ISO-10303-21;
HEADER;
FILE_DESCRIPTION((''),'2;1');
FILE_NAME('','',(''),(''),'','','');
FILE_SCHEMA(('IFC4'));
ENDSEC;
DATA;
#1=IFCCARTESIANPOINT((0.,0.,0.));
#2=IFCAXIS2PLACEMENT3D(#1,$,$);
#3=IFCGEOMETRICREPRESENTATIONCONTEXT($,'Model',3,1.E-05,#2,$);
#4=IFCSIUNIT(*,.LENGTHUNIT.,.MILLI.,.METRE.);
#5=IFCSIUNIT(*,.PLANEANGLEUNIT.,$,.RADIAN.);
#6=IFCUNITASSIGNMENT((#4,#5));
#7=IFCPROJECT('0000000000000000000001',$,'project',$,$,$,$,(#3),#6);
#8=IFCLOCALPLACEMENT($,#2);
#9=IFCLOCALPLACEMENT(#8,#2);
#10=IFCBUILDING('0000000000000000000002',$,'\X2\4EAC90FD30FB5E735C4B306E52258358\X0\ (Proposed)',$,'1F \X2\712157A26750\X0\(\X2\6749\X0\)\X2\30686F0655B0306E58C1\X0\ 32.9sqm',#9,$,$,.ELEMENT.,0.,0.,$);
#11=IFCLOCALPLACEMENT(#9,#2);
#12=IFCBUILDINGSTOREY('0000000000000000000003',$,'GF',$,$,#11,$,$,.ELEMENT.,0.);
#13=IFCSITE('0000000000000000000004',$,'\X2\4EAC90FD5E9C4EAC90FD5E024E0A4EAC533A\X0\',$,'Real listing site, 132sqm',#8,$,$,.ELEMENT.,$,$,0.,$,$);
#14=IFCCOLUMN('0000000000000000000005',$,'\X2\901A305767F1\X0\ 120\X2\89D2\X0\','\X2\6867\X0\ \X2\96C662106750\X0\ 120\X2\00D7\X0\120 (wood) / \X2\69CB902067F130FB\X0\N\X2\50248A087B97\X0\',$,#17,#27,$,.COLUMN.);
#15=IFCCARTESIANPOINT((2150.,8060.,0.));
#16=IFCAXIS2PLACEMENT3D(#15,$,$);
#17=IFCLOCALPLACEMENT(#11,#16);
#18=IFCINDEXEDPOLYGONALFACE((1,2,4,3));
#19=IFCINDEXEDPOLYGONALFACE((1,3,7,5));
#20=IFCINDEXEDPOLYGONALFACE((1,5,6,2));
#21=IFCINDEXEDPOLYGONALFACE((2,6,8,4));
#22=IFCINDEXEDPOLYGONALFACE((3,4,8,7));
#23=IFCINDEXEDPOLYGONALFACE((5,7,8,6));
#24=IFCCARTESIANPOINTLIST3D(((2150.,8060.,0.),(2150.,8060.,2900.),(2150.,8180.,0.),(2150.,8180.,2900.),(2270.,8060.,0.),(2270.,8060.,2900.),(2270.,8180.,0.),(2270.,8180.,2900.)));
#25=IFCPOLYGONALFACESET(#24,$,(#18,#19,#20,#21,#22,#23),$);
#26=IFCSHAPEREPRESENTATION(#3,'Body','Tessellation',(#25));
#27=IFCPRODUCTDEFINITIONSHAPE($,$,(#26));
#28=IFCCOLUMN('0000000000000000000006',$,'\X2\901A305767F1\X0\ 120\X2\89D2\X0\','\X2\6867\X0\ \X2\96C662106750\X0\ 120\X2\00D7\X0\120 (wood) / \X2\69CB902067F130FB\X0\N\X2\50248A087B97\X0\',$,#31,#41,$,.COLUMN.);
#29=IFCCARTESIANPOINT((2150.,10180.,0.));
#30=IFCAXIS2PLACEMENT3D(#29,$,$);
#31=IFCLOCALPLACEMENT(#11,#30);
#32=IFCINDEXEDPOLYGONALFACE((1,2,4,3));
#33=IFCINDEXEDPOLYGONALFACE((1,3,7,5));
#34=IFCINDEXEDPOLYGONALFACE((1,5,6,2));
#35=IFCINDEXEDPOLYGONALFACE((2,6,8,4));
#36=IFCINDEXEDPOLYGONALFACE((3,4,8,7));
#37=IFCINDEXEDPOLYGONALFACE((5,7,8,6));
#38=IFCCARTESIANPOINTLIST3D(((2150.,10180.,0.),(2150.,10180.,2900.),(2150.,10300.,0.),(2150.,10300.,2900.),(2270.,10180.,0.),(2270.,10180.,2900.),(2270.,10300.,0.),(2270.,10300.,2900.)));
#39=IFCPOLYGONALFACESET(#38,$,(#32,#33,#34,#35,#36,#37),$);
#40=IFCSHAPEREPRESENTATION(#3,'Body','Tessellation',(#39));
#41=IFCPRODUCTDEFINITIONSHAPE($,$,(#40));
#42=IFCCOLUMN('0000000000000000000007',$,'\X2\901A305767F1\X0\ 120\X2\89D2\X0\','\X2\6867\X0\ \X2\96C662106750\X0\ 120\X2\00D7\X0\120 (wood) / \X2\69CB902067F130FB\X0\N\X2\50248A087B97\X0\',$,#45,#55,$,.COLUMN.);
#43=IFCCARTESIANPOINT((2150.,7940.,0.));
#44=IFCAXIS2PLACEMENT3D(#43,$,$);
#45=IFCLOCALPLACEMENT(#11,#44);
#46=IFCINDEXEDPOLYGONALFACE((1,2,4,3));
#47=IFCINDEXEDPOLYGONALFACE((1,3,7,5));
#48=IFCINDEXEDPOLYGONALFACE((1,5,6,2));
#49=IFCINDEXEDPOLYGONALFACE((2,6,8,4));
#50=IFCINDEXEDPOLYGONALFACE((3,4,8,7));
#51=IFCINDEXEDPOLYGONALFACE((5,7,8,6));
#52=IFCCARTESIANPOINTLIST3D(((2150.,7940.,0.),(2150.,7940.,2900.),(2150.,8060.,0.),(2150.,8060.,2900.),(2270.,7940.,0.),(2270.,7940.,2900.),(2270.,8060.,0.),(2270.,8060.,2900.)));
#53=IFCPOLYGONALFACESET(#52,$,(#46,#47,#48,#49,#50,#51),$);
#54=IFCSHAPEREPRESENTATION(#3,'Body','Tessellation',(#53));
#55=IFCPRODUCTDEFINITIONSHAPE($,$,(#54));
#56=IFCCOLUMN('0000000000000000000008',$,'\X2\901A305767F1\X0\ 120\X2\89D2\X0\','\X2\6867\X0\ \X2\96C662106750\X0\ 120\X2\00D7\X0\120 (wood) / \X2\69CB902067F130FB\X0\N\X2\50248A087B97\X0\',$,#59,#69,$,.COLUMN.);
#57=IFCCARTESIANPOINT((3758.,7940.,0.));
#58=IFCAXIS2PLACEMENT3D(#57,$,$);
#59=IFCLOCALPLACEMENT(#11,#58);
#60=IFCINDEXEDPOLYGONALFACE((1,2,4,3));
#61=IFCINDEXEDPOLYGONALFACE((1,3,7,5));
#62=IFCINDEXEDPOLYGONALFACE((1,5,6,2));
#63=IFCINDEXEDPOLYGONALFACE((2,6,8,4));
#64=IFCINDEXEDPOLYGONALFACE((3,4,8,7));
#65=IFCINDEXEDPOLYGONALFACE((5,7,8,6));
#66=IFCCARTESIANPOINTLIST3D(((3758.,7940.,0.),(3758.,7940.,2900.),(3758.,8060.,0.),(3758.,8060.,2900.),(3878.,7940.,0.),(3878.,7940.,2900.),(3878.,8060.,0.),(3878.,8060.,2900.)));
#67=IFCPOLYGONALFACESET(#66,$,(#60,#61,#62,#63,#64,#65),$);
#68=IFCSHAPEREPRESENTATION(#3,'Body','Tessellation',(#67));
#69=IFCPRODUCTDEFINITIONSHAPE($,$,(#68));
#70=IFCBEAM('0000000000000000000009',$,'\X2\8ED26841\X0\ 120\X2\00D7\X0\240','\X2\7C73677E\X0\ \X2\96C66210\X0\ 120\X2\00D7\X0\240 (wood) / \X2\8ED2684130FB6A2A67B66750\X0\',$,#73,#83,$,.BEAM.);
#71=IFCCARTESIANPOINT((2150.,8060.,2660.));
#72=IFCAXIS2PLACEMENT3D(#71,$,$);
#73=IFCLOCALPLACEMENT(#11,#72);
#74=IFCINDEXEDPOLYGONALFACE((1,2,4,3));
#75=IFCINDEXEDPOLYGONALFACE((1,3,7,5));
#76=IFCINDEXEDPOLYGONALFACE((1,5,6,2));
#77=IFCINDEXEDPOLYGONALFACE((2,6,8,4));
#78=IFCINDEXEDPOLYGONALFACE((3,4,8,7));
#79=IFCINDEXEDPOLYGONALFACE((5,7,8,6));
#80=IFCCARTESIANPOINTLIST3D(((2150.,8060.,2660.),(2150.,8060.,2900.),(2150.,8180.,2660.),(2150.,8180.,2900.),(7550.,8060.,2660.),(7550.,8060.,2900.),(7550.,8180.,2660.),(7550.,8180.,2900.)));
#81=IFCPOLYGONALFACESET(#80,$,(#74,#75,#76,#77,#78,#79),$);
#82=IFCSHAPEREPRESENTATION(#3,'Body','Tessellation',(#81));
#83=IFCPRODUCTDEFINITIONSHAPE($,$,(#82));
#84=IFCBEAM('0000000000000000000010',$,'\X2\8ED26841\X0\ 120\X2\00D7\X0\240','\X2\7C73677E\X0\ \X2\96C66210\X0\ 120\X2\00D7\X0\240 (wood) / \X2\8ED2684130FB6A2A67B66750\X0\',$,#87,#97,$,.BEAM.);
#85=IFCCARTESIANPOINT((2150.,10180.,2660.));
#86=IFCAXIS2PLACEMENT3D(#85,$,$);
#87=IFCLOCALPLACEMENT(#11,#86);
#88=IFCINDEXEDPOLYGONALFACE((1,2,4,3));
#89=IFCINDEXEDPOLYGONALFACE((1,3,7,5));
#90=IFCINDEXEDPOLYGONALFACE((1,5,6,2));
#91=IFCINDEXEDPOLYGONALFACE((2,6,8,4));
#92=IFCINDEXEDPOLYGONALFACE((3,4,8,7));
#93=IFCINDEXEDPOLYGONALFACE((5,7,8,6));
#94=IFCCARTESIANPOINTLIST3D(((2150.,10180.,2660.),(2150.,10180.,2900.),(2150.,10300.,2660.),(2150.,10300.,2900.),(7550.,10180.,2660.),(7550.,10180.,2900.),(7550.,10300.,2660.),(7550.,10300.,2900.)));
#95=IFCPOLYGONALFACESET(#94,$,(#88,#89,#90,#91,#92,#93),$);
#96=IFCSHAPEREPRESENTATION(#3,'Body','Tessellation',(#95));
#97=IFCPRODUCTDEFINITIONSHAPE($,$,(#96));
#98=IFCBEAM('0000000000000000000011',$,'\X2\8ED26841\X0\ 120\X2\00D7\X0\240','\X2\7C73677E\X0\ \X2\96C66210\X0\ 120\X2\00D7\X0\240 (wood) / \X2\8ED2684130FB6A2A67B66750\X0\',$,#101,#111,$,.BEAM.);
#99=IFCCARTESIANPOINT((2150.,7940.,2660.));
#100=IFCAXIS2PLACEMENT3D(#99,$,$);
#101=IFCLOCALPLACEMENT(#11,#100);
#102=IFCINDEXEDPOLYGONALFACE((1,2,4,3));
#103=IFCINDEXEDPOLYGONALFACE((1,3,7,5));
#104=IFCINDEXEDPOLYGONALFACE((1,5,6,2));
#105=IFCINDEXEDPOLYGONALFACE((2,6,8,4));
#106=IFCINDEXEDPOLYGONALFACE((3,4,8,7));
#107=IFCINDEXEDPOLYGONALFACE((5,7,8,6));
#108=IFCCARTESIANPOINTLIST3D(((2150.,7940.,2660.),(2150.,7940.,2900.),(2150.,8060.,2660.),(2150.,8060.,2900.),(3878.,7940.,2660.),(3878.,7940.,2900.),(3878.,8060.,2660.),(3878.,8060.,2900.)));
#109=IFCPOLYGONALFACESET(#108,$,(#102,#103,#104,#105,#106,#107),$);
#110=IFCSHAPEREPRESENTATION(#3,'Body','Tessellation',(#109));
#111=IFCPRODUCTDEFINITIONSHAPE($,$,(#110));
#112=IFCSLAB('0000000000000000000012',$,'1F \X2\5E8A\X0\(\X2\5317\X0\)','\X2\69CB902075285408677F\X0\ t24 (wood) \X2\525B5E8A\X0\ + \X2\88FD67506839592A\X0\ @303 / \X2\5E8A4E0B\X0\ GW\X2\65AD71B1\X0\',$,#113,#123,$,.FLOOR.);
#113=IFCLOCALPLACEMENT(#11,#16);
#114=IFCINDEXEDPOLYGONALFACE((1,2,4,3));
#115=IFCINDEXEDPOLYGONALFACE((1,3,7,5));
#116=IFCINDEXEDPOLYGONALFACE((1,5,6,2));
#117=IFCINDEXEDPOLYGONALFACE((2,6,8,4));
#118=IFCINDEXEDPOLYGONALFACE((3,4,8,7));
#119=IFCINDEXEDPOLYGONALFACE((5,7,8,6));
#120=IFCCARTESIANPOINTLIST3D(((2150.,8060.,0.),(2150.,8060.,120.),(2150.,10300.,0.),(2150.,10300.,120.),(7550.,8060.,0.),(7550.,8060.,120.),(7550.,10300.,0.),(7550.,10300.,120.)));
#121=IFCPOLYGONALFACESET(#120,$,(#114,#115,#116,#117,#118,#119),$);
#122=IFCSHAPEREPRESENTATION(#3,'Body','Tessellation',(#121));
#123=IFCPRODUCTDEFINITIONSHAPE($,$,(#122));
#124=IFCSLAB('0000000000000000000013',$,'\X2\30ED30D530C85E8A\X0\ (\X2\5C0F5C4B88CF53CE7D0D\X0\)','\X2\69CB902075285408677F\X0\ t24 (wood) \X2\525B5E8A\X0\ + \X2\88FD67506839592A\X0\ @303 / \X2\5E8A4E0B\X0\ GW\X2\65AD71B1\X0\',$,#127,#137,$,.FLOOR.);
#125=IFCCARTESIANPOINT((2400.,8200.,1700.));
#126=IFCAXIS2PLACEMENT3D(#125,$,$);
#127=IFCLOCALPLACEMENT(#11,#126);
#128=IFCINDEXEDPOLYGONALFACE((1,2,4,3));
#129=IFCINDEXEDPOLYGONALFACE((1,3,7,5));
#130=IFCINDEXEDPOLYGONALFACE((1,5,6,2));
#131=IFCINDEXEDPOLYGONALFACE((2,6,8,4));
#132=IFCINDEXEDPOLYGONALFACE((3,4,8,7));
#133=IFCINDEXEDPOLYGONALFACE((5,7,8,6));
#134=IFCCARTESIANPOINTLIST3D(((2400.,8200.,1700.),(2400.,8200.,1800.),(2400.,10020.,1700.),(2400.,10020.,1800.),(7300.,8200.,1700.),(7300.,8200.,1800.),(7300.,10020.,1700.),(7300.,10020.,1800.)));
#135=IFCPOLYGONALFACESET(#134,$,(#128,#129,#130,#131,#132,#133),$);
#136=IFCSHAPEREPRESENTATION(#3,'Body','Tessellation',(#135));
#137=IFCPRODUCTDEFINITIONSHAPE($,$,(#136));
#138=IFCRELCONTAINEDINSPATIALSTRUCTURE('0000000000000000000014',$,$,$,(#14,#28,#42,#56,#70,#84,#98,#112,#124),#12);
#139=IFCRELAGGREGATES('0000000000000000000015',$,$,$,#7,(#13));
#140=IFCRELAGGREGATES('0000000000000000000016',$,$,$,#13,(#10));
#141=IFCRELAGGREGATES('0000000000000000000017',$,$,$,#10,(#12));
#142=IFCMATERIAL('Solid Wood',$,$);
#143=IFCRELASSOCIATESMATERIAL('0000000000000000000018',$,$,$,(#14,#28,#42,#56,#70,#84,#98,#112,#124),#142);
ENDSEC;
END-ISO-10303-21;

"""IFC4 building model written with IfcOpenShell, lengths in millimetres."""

from ifc_helpers import new_model, si_unit, frame, frame_2d, origin, place, context, project, spatial, rectangle, extrude, material, element, save


model = new_model("IFC4")

# Units and contexts
model_context = context("Model", 3, precision=1e-05, world=origin())
ifc_project = project(units=[si_unit("LENGTHUNIT", "METRE", prefix="MILLI"), si_unit("PLANEANGLEUNIT", "RADIAN")], contexts=[model_context])

# Site, building, storey
site_placement = place(None, origin())
site = spatial("IfcSite", under=ifc_project, at=site_placement, Name="京都府京都市上京区", ObjectType="Real listing site, 132sqm", CompositionType="ELEMENT", RefElevation=0.0)
building_placement = place(site_placement, origin())
building = spatial("IfcBuilding", under=site, at=building_placement, Name="京都・平屋の別荘 (Proposed)", ObjectType="1F 無垢材(杉)と漆喰の壁 32.9sqm", CompositionType="ELEMENT", ElevationOfRefHeight=0.0, ElevationOfTerrain=0.0)
storey_placement = place(building_placement, origin())
storey = spatial("IfcBuildingStorey", under=building, at=storey_placement, Name="GF", CompositionType="ELEMENT", Elevation=0.0)

# Columns
ifc_material_1 = material(Name="Solid Wood")
column_1_placement = place(storey_placement, frame((2150.0, 8060.0, 0.0)))
element("IfcColumn", 1, at=column_1_placement, inside=storey, material=ifc_material_1, Name="通し柱 120角", Description="桧 集成材 120×120 (wood) / 構造柱・N値計算", PredefinedType="COLUMN", context=model_context, shape_type="SweptSolid", body=[
    extrude(rectangle(XDim=120.0, YDim=120.0, at=frame_2d((60.0, 60.0))), frame((2150.0, 8060.0, 0.0)), (0.0, 0.0, 1.0), 2900.0),
])
column_2_placement = place(storey_placement, frame((2150.0, 10180.0, 0.0)))
element("IfcColumn", 2, at=column_2_placement, inside=storey, material=ifc_material_1, Name="通し柱 120角", Description="桧 集成材 120×120 (wood) / 構造柱・N値計算", PredefinedType="COLUMN", context=model_context, shape_type="SweptSolid", body=[
    extrude(rectangle(XDim=120.0, YDim=120.0, at=frame_2d((60.0, 60.0))), frame((2150.0, 10180.0, 0.0)), (0.0, 0.0, 1.0), 2900.0),
])
column_3_placement = place(storey_placement, frame((2150.0, 7940.0, 0.0)))
element("IfcColumn", 3, at=column_3_placement, inside=storey, material=ifc_material_1, Name="通し柱 120角", Description="桧 集成材 120×120 (wood) / 構造柱・N値計算", PredefinedType="COLUMN", context=model_context, shape_type="SweptSolid", body=[
    extrude(rectangle(XDim=120.0, YDim=120.0, at=frame_2d((60.0, 60.0))), frame((2150.0, 7940.0, 0.0)), (0.0, 0.0, 1.0), 2900.0),
])
column_4_placement = place(storey_placement, frame((3758.0, 7940.0, 0.0)))
element("IfcColumn", 4, at=column_4_placement, inside=storey, material=ifc_material_1, Name="通し柱 120角", Description="桧 集成材 120×120 (wood) / 構造柱・N値計算", PredefinedType="COLUMN", context=model_context, shape_type="SweptSolid", body=[
    extrude(rectangle(XDim=120.0, YDim=120.0, at=frame_2d((60.0, 60.0))), frame((3758.0, 7940.0, 0.0)), (0.0, 0.0, 1.0), 2900.0),
])

# Beams
beam_1_placement = place(storey_placement, frame((2150.0, 8060.0, 2660.0)))
element("IfcBeam", 5, at=beam_1_placement, inside=storey, material=ifc_material_1, Name="軒桁 120×240", Description="米松 集成 120×240 (wood) / 軒桁・横架材", PredefinedType="BEAM", context=model_context, shape_type="SweptSolid", body=[
    extrude(rectangle(XDim=5400.0, YDim=120.0, at=frame_2d((2700.0, 60.0))), frame((2150.0, 8060.0, 2660.0)), (0.0, 0.0, 1.0), 240.0),
])
beam_2_placement = place(storey_placement, frame((2150.0, 10180.0, 2660.0)))
element("IfcBeam", 6, at=beam_2_placement, inside=storey, material=ifc_material_1, Name="軒桁 120×240", Description="米松 集成 120×240 (wood) / 軒桁・横架材", PredefinedType="BEAM", context=model_context, shape_type="SweptSolid", body=[
    extrude(rectangle(XDim=5400.0, YDim=120.0, at=frame_2d((2700.0, 60.0))), frame((2150.0, 10180.0, 2660.0)), (0.0, 0.0, 1.0), 240.0),
])
beam_3_placement = place(storey_placement, frame((2150.0, 7940.0, 2660.0)))
element("IfcBeam", 7, at=beam_3_placement, inside=storey, material=ifc_material_1, Name="軒桁 120×240", Description="米松 集成 120×240 (wood) / 軒桁・横架材", PredefinedType="BEAM", context=model_context, shape_type="SweptSolid", body=[
    extrude(rectangle(XDim=1728.0, YDim=120.0, at=frame_2d((864.0, 60.0))), frame((2150.0, 7940.0, 2660.0)), (0.0, 0.0, 1.0), 240.0),
])

# Slabs
slab_1_placement = place(storey_placement, frame((2150.0, 8060.0, 0.0)))
element("IfcSlab", 8, at=slab_1_placement, inside=storey, material=ifc_material_1, Name="1F 床(北)", Description="構造用合板 t24 (wood) 剛床 + 製材根太 @303 / 床下 GW断熱", PredefinedType="FLOOR", context=model_context, shape_type="SweptSolid", body=[
    extrude(rectangle(XDim=5400.0, YDim=2240.0, at=frame_2d((2700.0, 1120.0))), frame((2150.0, 8060.0, 0.0)), (0.0, 0.0, 1.0), 120.0),
])
slab_2_placement = place(storey_placement, frame((2400.0, 8200.0, 1700.0)))
element("IfcSlab", 9, at=slab_2_placement, inside=storey, material=ifc_material_1, Name="ロフト床 (小屋裏収納)", Description="構造用合板 t24 (wood) 剛床 + 製材根太 @303 / 床下 GW断熱", PredefinedType="FLOOR", context=model_context, shape_type="SweptSolid", body=[
    extrude(rectangle(XDim=4900.0, YDim=1820.0, at=frame_2d((2450.0, 910.0))), frame((2400.0, 8200.0, 1700.0)), (0.0, 0.0, 1.0), 100.0),
])

save(model, "model.ifc")
